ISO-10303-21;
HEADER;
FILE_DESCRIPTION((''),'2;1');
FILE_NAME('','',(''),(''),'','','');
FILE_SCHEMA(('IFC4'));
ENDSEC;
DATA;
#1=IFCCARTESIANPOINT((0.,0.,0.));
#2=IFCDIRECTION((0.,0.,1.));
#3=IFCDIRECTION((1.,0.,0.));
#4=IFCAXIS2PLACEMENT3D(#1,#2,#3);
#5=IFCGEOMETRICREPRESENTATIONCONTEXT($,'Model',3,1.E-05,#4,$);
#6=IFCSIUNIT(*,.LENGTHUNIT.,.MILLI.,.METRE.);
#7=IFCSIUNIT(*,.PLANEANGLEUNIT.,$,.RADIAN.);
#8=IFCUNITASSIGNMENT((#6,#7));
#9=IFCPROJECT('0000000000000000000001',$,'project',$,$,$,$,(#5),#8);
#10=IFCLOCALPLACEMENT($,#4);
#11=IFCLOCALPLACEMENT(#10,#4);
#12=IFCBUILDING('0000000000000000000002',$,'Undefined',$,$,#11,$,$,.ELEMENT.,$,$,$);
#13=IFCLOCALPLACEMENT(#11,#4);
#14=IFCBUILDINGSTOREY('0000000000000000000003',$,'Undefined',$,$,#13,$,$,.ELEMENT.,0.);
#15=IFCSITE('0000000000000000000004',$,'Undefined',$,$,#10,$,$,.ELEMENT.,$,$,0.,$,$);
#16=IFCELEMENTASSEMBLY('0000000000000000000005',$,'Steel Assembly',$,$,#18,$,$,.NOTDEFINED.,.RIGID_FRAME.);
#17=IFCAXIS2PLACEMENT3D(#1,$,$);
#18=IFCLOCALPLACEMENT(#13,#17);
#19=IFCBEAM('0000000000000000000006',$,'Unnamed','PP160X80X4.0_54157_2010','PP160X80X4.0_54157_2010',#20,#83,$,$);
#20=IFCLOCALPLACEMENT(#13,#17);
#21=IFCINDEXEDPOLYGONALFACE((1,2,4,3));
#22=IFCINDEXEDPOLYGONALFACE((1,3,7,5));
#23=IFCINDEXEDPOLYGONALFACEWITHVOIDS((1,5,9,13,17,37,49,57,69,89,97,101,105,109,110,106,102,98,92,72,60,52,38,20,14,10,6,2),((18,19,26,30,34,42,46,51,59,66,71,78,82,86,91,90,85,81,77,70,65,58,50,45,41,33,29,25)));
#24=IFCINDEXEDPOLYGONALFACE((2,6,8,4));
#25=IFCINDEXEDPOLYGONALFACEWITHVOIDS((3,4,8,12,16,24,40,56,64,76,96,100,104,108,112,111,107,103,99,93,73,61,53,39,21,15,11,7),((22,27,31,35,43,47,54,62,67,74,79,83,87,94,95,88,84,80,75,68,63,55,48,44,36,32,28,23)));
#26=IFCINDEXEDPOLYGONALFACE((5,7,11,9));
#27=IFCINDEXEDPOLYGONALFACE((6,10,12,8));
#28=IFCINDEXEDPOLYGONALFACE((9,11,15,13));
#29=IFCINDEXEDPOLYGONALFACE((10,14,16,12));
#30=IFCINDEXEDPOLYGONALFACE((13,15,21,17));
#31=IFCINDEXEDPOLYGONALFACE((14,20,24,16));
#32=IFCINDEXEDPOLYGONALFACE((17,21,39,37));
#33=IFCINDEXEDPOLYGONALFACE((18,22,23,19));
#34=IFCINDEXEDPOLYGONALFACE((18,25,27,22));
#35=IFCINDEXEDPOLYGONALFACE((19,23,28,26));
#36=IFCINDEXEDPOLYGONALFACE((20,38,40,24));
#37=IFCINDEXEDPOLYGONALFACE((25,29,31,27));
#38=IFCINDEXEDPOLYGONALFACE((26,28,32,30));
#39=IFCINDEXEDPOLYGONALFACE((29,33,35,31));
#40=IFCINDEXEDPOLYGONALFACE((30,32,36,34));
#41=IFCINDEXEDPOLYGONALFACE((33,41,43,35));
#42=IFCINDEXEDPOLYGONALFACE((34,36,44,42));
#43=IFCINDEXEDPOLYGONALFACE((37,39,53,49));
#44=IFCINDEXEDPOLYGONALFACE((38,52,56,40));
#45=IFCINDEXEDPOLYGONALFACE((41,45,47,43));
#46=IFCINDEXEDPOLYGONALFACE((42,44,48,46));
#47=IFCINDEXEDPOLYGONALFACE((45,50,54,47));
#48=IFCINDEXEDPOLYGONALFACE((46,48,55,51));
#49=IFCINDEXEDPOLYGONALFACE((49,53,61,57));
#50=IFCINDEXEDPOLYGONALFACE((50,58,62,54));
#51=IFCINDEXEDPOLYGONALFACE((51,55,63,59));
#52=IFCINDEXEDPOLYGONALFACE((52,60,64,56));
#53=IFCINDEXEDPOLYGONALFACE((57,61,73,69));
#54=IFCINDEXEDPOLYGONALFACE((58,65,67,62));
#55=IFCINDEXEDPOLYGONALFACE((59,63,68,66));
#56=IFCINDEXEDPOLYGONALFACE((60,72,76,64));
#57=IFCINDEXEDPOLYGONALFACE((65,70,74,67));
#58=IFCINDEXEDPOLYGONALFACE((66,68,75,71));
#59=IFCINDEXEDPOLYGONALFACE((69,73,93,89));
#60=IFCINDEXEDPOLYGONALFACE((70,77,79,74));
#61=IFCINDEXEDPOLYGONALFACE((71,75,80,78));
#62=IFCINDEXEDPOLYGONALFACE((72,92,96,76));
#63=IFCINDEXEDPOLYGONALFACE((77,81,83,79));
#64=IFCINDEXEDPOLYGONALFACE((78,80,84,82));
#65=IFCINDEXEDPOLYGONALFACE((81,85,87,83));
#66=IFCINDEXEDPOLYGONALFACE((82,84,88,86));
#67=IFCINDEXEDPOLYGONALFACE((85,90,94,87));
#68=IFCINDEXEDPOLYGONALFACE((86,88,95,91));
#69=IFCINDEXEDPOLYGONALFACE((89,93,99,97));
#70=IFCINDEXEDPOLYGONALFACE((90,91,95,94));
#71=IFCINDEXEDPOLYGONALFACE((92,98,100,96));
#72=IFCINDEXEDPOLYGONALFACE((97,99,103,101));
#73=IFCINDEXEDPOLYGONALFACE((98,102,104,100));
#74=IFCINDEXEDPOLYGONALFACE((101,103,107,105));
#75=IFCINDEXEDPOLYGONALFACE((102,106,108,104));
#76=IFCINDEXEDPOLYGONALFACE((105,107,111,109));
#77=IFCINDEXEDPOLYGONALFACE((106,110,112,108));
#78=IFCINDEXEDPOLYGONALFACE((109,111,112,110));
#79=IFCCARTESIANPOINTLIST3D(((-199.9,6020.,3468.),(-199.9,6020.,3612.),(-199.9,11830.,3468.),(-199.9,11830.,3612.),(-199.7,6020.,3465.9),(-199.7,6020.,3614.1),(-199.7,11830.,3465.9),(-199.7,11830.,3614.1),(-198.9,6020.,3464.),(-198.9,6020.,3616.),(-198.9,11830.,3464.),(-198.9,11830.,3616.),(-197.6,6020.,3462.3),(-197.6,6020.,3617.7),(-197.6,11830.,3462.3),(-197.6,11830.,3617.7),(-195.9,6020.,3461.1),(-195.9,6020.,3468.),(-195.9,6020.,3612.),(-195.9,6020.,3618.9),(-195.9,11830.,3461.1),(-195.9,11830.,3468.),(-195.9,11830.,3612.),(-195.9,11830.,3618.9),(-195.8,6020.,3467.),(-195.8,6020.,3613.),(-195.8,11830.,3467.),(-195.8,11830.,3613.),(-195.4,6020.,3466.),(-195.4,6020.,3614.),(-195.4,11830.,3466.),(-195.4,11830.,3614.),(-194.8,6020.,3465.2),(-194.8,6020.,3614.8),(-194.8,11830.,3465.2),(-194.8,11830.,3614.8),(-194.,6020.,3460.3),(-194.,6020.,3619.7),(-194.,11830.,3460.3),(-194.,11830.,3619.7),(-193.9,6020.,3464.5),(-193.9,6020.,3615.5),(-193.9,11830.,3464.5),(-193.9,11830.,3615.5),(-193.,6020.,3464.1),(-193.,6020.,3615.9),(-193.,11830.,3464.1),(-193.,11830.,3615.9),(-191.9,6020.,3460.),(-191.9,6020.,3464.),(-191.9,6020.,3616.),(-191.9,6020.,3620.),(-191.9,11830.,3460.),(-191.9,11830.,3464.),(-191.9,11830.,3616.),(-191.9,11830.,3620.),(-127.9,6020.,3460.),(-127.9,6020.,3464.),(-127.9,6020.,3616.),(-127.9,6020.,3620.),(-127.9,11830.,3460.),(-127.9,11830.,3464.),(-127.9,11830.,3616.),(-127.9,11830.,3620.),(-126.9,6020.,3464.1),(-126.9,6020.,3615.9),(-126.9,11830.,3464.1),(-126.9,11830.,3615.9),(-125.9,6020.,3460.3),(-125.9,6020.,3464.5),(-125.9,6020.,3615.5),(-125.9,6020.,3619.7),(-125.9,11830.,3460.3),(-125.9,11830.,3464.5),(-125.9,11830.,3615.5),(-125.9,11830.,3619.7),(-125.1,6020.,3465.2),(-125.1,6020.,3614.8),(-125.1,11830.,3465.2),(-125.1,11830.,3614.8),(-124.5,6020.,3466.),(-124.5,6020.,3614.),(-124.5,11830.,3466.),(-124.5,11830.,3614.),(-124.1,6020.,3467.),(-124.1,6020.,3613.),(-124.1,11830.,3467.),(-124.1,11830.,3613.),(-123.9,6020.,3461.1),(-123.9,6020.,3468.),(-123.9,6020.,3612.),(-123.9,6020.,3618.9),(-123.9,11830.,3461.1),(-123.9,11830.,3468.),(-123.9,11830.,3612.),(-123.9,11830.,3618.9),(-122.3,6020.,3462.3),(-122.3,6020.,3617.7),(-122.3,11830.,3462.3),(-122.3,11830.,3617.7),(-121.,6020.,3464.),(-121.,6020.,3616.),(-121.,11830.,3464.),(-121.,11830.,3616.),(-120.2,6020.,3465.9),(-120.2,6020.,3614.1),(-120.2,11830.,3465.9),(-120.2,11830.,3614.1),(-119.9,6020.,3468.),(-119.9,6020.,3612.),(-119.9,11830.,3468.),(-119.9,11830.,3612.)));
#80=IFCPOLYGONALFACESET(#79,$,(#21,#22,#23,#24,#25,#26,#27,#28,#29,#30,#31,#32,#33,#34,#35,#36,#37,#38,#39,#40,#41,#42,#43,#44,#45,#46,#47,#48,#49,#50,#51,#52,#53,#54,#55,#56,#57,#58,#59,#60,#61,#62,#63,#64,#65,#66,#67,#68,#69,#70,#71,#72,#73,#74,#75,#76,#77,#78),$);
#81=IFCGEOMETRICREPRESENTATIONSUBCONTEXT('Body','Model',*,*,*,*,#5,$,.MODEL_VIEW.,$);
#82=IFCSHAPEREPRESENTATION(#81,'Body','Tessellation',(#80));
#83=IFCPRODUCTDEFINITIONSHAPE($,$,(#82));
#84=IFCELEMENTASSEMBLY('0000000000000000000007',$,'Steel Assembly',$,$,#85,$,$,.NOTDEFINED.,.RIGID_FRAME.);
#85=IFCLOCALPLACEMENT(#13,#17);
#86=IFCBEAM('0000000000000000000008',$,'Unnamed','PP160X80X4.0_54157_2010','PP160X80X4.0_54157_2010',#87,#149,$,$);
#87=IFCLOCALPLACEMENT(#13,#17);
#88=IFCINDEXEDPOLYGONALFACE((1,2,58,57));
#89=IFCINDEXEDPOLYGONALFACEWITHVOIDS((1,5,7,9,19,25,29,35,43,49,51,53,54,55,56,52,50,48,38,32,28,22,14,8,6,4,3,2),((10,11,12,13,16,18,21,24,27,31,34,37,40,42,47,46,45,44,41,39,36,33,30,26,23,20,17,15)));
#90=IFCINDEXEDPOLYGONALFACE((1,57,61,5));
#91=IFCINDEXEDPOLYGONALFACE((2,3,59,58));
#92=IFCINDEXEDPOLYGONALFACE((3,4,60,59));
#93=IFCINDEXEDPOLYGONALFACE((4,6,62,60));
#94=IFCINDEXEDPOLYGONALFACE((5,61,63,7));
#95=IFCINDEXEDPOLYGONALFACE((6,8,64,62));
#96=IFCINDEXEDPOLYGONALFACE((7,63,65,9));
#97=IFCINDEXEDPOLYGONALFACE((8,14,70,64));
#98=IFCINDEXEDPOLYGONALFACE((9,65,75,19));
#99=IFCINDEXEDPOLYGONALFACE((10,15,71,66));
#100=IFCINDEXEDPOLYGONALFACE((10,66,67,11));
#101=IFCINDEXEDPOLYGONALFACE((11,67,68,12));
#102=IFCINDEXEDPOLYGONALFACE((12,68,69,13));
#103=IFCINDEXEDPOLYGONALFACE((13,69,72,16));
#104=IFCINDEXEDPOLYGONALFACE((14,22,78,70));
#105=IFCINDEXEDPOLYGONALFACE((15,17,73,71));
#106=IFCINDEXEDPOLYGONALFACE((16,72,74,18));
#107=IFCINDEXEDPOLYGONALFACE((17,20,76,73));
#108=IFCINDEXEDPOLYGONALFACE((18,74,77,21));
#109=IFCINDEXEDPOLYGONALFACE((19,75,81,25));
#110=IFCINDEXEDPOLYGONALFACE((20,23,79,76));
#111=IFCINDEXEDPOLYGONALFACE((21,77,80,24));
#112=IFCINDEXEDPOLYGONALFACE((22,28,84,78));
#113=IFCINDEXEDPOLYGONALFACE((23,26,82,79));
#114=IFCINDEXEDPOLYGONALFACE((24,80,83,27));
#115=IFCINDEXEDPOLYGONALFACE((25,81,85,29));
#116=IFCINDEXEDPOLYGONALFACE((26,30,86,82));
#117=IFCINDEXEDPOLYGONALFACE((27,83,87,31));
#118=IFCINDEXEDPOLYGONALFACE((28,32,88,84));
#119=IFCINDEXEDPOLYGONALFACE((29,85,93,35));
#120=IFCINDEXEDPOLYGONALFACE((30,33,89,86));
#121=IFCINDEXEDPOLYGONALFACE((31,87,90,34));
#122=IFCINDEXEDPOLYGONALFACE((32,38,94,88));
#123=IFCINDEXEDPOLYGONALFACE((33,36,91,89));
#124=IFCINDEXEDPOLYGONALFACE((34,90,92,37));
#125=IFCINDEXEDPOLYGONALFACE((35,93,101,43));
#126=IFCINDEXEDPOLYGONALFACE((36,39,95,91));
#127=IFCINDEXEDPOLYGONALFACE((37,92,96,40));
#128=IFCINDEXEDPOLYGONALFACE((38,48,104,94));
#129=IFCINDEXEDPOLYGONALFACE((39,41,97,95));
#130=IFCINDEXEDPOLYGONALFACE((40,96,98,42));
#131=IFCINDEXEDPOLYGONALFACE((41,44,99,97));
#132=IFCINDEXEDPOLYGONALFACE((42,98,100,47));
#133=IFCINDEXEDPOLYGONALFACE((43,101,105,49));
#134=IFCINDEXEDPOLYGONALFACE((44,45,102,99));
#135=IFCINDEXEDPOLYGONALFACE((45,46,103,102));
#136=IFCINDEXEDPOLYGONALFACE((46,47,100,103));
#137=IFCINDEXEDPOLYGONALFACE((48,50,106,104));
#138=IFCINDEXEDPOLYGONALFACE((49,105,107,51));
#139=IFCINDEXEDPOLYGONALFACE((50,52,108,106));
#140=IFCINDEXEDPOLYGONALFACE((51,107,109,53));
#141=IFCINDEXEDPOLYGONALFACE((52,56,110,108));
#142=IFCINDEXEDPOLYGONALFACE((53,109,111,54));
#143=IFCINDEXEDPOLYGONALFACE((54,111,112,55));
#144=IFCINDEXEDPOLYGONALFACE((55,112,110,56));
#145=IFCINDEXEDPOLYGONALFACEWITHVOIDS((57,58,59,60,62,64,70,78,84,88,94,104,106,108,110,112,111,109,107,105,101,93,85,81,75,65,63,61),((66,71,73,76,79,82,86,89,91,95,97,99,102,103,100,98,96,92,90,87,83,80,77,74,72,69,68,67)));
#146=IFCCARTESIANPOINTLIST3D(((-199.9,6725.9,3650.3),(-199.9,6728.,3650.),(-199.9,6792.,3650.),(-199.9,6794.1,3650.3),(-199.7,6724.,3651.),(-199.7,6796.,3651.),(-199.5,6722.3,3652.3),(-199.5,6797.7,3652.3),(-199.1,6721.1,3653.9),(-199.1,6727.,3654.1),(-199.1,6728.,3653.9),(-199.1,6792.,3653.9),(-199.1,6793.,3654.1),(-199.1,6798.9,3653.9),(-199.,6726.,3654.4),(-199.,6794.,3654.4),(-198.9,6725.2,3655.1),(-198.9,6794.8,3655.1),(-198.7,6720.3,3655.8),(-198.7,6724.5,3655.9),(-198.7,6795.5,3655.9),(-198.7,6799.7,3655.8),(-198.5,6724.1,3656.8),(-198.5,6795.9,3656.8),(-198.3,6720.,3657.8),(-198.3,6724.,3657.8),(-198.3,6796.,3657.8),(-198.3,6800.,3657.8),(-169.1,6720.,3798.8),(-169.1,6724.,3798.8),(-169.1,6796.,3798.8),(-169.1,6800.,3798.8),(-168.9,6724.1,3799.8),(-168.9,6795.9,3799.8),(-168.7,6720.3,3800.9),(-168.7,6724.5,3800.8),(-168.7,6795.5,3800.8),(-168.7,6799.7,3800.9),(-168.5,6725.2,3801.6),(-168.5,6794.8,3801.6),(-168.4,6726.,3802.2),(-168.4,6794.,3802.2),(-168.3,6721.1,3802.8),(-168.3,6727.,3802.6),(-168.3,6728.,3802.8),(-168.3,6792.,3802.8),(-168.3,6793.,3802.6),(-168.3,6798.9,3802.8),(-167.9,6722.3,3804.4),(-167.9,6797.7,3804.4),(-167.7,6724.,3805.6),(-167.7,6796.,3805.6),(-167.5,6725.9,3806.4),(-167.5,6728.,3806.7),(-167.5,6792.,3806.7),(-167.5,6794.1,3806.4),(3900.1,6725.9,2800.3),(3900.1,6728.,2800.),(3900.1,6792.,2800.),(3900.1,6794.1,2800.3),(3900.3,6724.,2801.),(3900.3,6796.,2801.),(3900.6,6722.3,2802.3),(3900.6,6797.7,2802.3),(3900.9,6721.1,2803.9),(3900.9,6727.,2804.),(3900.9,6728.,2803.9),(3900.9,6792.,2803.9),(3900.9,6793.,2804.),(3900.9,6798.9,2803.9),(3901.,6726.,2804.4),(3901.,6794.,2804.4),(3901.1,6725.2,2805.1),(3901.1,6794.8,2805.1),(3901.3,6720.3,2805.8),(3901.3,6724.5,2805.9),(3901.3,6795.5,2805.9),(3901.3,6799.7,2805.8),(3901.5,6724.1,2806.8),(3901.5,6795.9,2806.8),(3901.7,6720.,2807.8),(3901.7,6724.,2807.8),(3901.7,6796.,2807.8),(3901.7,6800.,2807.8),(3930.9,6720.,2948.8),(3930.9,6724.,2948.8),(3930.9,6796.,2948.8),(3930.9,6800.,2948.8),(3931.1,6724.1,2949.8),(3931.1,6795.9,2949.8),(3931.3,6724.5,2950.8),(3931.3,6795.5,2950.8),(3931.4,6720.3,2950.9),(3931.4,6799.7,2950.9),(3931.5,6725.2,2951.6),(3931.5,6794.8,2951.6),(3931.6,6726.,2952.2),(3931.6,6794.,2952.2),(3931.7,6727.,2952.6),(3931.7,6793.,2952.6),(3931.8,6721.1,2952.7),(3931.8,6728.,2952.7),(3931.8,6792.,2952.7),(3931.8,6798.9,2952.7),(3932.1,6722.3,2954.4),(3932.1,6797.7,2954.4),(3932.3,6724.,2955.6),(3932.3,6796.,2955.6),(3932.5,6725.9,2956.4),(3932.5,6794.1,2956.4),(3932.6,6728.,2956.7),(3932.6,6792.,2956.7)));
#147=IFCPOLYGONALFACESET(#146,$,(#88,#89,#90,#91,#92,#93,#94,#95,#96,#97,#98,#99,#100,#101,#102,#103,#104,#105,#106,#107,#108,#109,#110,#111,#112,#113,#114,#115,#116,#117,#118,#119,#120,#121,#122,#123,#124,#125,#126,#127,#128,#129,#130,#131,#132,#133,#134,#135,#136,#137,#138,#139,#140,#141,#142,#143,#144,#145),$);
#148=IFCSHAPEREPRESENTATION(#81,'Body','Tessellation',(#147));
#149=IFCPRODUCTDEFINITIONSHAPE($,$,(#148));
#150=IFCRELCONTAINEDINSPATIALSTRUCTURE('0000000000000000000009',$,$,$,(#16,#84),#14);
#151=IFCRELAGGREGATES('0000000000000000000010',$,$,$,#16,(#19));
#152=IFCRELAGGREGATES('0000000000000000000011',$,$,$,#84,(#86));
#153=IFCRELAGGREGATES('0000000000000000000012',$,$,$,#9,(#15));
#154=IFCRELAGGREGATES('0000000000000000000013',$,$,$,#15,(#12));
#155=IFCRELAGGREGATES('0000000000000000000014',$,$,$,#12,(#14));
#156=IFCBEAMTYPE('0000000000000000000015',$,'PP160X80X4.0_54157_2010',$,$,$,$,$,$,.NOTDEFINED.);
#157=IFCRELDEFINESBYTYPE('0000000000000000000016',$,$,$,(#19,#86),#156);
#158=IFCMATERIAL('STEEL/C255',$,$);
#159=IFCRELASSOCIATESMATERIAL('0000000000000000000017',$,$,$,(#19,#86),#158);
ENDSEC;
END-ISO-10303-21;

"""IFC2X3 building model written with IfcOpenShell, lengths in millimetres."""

from ifc_helpers import new_model, si_unit, frame, origin_with_axes, origin_2d_with_axis, place, context, subcontext, project, spatial, hollow_rectangle, extrude, material, type_object, element, aggregate, save


model = new_model("IFC2X3")

# Units and contexts
model_context = context("Model", 3, precision=1e-05, world=origin_with_axes())
body_context = subcontext(model_context, "Body", "Model", "MODEL_VIEW")
ifc_project = project(units=[si_unit("LENGTHUNIT", "METRE", prefix="MILLI"), si_unit("PLANEANGLEUNIT", "RADIAN")], contexts=[model_context])

# Site, building, storey
site_placement = place(None, origin_with_axes())
site = spatial("IfcSite", under=ifc_project, at=site_placement, Name="Undefined", CompositionType="ELEMENT", RefElevation=0.0)
building_placement = place(site_placement, origin_with_axes())
building = spatial("IfcBuilding", under=site, at=building_placement, Name="Undefined", CompositionType="ELEMENT")
storey_placement = place(building_placement, origin_with_axes())
storey = spatial("IfcBuildingStorey", under=building, at=storey_placement, Name="Undefined", CompositionType="ELEMENT", Elevation=0.0)

# Element assemblies, beams
ifc_material_1 = material(Name="STEEL/C255")
beam_type_1 = type_object("IfcBeamType", Name="PP160X80X4.0_54157_2010", PredefinedType="NOTDEFINED")
assembly_1_placement = place(storey_placement, origin_with_axes())
assembly_1 = element("IfcElementAssembly", 1, at=assembly_1_placement, inside=storey, Name="Steel Assembly", AssemblyPlace="NOTDEFINED", PredefinedType="RIGID_FRAME")
beam_1_placement = place(assembly_1_placement, frame((-159.9, 6020.0, 3540.0), z_axis=(0.0, 0.0, 1.0), x_axis=(0.0, 1.0, 0.0)))
beam_1 = element("IfcBeam", 2, at=beam_1_placement, type_object=beam_type_1, material=ifc_material_1, Name="Unnamed", Description="PP160X80X4.0_54157_2010", ObjectType="PP160X80X4.0_54157_2010", context=body_context, shape_type="SweptSolid", body=[
    extrude(hollow_rectangle(XDim=80.0, YDim=160.0, WallThickness=4.0, InnerFilletRadius=4.0, OuterFilletRadius=8.0, at=origin_2d_with_axis()), frame((5810.0, 0.0, 0.0), z_axis=(-1.0, 0.0, 0.0), x_axis=(0.0, -1.0, 0.0)), (0.0, 0.0, 1.0), 5810.0),
])
aggregate(assembly_1, [beam_1])
assembly_2_placement = place(storey_placement, origin_with_axes())
assembly_2 = element("IfcElementAssembly", 3, at=assembly_2_placement, inside=storey, Name="Steel Assembly", AssemblyPlace="NOTDEFINED", PredefinedType="RIGID_FRAME")
beam_2_placement = place(assembly_2_placement, frame((3916.3, 6760.0, 2878.3), z_axis=(0.203, 0.0, 0.979179), x_axis=(-0.979179, 0.0, 0.203)))
beam_2 = element("IfcBeam", 4, at=beam_2_placement, type_object=beam_type_1, material=ifc_material_1, Name="Unnamed", Description="PP160X80X4.0_54157_2010", ObjectType="PP160X80X4.0_54157_2010", context=body_context, shape_type="SweptSolid", body=[
    extrude(hollow_rectangle(XDim=80.0, YDim=160.0, WallThickness=4.0, InnerFilletRadius=4.0, OuterFilletRadius=8.0, at=origin_2d_with_axis()), frame((4187.2, 0.0, 0.0), z_axis=(-1.0, 0.0, 0.0), x_axis=(0.0, -1.0, 0.0)), (0.0, 0.0, 1.0), 4187.2),
])
aggregate(assembly_2, [beam_2])

save(model, "model.ifc")
